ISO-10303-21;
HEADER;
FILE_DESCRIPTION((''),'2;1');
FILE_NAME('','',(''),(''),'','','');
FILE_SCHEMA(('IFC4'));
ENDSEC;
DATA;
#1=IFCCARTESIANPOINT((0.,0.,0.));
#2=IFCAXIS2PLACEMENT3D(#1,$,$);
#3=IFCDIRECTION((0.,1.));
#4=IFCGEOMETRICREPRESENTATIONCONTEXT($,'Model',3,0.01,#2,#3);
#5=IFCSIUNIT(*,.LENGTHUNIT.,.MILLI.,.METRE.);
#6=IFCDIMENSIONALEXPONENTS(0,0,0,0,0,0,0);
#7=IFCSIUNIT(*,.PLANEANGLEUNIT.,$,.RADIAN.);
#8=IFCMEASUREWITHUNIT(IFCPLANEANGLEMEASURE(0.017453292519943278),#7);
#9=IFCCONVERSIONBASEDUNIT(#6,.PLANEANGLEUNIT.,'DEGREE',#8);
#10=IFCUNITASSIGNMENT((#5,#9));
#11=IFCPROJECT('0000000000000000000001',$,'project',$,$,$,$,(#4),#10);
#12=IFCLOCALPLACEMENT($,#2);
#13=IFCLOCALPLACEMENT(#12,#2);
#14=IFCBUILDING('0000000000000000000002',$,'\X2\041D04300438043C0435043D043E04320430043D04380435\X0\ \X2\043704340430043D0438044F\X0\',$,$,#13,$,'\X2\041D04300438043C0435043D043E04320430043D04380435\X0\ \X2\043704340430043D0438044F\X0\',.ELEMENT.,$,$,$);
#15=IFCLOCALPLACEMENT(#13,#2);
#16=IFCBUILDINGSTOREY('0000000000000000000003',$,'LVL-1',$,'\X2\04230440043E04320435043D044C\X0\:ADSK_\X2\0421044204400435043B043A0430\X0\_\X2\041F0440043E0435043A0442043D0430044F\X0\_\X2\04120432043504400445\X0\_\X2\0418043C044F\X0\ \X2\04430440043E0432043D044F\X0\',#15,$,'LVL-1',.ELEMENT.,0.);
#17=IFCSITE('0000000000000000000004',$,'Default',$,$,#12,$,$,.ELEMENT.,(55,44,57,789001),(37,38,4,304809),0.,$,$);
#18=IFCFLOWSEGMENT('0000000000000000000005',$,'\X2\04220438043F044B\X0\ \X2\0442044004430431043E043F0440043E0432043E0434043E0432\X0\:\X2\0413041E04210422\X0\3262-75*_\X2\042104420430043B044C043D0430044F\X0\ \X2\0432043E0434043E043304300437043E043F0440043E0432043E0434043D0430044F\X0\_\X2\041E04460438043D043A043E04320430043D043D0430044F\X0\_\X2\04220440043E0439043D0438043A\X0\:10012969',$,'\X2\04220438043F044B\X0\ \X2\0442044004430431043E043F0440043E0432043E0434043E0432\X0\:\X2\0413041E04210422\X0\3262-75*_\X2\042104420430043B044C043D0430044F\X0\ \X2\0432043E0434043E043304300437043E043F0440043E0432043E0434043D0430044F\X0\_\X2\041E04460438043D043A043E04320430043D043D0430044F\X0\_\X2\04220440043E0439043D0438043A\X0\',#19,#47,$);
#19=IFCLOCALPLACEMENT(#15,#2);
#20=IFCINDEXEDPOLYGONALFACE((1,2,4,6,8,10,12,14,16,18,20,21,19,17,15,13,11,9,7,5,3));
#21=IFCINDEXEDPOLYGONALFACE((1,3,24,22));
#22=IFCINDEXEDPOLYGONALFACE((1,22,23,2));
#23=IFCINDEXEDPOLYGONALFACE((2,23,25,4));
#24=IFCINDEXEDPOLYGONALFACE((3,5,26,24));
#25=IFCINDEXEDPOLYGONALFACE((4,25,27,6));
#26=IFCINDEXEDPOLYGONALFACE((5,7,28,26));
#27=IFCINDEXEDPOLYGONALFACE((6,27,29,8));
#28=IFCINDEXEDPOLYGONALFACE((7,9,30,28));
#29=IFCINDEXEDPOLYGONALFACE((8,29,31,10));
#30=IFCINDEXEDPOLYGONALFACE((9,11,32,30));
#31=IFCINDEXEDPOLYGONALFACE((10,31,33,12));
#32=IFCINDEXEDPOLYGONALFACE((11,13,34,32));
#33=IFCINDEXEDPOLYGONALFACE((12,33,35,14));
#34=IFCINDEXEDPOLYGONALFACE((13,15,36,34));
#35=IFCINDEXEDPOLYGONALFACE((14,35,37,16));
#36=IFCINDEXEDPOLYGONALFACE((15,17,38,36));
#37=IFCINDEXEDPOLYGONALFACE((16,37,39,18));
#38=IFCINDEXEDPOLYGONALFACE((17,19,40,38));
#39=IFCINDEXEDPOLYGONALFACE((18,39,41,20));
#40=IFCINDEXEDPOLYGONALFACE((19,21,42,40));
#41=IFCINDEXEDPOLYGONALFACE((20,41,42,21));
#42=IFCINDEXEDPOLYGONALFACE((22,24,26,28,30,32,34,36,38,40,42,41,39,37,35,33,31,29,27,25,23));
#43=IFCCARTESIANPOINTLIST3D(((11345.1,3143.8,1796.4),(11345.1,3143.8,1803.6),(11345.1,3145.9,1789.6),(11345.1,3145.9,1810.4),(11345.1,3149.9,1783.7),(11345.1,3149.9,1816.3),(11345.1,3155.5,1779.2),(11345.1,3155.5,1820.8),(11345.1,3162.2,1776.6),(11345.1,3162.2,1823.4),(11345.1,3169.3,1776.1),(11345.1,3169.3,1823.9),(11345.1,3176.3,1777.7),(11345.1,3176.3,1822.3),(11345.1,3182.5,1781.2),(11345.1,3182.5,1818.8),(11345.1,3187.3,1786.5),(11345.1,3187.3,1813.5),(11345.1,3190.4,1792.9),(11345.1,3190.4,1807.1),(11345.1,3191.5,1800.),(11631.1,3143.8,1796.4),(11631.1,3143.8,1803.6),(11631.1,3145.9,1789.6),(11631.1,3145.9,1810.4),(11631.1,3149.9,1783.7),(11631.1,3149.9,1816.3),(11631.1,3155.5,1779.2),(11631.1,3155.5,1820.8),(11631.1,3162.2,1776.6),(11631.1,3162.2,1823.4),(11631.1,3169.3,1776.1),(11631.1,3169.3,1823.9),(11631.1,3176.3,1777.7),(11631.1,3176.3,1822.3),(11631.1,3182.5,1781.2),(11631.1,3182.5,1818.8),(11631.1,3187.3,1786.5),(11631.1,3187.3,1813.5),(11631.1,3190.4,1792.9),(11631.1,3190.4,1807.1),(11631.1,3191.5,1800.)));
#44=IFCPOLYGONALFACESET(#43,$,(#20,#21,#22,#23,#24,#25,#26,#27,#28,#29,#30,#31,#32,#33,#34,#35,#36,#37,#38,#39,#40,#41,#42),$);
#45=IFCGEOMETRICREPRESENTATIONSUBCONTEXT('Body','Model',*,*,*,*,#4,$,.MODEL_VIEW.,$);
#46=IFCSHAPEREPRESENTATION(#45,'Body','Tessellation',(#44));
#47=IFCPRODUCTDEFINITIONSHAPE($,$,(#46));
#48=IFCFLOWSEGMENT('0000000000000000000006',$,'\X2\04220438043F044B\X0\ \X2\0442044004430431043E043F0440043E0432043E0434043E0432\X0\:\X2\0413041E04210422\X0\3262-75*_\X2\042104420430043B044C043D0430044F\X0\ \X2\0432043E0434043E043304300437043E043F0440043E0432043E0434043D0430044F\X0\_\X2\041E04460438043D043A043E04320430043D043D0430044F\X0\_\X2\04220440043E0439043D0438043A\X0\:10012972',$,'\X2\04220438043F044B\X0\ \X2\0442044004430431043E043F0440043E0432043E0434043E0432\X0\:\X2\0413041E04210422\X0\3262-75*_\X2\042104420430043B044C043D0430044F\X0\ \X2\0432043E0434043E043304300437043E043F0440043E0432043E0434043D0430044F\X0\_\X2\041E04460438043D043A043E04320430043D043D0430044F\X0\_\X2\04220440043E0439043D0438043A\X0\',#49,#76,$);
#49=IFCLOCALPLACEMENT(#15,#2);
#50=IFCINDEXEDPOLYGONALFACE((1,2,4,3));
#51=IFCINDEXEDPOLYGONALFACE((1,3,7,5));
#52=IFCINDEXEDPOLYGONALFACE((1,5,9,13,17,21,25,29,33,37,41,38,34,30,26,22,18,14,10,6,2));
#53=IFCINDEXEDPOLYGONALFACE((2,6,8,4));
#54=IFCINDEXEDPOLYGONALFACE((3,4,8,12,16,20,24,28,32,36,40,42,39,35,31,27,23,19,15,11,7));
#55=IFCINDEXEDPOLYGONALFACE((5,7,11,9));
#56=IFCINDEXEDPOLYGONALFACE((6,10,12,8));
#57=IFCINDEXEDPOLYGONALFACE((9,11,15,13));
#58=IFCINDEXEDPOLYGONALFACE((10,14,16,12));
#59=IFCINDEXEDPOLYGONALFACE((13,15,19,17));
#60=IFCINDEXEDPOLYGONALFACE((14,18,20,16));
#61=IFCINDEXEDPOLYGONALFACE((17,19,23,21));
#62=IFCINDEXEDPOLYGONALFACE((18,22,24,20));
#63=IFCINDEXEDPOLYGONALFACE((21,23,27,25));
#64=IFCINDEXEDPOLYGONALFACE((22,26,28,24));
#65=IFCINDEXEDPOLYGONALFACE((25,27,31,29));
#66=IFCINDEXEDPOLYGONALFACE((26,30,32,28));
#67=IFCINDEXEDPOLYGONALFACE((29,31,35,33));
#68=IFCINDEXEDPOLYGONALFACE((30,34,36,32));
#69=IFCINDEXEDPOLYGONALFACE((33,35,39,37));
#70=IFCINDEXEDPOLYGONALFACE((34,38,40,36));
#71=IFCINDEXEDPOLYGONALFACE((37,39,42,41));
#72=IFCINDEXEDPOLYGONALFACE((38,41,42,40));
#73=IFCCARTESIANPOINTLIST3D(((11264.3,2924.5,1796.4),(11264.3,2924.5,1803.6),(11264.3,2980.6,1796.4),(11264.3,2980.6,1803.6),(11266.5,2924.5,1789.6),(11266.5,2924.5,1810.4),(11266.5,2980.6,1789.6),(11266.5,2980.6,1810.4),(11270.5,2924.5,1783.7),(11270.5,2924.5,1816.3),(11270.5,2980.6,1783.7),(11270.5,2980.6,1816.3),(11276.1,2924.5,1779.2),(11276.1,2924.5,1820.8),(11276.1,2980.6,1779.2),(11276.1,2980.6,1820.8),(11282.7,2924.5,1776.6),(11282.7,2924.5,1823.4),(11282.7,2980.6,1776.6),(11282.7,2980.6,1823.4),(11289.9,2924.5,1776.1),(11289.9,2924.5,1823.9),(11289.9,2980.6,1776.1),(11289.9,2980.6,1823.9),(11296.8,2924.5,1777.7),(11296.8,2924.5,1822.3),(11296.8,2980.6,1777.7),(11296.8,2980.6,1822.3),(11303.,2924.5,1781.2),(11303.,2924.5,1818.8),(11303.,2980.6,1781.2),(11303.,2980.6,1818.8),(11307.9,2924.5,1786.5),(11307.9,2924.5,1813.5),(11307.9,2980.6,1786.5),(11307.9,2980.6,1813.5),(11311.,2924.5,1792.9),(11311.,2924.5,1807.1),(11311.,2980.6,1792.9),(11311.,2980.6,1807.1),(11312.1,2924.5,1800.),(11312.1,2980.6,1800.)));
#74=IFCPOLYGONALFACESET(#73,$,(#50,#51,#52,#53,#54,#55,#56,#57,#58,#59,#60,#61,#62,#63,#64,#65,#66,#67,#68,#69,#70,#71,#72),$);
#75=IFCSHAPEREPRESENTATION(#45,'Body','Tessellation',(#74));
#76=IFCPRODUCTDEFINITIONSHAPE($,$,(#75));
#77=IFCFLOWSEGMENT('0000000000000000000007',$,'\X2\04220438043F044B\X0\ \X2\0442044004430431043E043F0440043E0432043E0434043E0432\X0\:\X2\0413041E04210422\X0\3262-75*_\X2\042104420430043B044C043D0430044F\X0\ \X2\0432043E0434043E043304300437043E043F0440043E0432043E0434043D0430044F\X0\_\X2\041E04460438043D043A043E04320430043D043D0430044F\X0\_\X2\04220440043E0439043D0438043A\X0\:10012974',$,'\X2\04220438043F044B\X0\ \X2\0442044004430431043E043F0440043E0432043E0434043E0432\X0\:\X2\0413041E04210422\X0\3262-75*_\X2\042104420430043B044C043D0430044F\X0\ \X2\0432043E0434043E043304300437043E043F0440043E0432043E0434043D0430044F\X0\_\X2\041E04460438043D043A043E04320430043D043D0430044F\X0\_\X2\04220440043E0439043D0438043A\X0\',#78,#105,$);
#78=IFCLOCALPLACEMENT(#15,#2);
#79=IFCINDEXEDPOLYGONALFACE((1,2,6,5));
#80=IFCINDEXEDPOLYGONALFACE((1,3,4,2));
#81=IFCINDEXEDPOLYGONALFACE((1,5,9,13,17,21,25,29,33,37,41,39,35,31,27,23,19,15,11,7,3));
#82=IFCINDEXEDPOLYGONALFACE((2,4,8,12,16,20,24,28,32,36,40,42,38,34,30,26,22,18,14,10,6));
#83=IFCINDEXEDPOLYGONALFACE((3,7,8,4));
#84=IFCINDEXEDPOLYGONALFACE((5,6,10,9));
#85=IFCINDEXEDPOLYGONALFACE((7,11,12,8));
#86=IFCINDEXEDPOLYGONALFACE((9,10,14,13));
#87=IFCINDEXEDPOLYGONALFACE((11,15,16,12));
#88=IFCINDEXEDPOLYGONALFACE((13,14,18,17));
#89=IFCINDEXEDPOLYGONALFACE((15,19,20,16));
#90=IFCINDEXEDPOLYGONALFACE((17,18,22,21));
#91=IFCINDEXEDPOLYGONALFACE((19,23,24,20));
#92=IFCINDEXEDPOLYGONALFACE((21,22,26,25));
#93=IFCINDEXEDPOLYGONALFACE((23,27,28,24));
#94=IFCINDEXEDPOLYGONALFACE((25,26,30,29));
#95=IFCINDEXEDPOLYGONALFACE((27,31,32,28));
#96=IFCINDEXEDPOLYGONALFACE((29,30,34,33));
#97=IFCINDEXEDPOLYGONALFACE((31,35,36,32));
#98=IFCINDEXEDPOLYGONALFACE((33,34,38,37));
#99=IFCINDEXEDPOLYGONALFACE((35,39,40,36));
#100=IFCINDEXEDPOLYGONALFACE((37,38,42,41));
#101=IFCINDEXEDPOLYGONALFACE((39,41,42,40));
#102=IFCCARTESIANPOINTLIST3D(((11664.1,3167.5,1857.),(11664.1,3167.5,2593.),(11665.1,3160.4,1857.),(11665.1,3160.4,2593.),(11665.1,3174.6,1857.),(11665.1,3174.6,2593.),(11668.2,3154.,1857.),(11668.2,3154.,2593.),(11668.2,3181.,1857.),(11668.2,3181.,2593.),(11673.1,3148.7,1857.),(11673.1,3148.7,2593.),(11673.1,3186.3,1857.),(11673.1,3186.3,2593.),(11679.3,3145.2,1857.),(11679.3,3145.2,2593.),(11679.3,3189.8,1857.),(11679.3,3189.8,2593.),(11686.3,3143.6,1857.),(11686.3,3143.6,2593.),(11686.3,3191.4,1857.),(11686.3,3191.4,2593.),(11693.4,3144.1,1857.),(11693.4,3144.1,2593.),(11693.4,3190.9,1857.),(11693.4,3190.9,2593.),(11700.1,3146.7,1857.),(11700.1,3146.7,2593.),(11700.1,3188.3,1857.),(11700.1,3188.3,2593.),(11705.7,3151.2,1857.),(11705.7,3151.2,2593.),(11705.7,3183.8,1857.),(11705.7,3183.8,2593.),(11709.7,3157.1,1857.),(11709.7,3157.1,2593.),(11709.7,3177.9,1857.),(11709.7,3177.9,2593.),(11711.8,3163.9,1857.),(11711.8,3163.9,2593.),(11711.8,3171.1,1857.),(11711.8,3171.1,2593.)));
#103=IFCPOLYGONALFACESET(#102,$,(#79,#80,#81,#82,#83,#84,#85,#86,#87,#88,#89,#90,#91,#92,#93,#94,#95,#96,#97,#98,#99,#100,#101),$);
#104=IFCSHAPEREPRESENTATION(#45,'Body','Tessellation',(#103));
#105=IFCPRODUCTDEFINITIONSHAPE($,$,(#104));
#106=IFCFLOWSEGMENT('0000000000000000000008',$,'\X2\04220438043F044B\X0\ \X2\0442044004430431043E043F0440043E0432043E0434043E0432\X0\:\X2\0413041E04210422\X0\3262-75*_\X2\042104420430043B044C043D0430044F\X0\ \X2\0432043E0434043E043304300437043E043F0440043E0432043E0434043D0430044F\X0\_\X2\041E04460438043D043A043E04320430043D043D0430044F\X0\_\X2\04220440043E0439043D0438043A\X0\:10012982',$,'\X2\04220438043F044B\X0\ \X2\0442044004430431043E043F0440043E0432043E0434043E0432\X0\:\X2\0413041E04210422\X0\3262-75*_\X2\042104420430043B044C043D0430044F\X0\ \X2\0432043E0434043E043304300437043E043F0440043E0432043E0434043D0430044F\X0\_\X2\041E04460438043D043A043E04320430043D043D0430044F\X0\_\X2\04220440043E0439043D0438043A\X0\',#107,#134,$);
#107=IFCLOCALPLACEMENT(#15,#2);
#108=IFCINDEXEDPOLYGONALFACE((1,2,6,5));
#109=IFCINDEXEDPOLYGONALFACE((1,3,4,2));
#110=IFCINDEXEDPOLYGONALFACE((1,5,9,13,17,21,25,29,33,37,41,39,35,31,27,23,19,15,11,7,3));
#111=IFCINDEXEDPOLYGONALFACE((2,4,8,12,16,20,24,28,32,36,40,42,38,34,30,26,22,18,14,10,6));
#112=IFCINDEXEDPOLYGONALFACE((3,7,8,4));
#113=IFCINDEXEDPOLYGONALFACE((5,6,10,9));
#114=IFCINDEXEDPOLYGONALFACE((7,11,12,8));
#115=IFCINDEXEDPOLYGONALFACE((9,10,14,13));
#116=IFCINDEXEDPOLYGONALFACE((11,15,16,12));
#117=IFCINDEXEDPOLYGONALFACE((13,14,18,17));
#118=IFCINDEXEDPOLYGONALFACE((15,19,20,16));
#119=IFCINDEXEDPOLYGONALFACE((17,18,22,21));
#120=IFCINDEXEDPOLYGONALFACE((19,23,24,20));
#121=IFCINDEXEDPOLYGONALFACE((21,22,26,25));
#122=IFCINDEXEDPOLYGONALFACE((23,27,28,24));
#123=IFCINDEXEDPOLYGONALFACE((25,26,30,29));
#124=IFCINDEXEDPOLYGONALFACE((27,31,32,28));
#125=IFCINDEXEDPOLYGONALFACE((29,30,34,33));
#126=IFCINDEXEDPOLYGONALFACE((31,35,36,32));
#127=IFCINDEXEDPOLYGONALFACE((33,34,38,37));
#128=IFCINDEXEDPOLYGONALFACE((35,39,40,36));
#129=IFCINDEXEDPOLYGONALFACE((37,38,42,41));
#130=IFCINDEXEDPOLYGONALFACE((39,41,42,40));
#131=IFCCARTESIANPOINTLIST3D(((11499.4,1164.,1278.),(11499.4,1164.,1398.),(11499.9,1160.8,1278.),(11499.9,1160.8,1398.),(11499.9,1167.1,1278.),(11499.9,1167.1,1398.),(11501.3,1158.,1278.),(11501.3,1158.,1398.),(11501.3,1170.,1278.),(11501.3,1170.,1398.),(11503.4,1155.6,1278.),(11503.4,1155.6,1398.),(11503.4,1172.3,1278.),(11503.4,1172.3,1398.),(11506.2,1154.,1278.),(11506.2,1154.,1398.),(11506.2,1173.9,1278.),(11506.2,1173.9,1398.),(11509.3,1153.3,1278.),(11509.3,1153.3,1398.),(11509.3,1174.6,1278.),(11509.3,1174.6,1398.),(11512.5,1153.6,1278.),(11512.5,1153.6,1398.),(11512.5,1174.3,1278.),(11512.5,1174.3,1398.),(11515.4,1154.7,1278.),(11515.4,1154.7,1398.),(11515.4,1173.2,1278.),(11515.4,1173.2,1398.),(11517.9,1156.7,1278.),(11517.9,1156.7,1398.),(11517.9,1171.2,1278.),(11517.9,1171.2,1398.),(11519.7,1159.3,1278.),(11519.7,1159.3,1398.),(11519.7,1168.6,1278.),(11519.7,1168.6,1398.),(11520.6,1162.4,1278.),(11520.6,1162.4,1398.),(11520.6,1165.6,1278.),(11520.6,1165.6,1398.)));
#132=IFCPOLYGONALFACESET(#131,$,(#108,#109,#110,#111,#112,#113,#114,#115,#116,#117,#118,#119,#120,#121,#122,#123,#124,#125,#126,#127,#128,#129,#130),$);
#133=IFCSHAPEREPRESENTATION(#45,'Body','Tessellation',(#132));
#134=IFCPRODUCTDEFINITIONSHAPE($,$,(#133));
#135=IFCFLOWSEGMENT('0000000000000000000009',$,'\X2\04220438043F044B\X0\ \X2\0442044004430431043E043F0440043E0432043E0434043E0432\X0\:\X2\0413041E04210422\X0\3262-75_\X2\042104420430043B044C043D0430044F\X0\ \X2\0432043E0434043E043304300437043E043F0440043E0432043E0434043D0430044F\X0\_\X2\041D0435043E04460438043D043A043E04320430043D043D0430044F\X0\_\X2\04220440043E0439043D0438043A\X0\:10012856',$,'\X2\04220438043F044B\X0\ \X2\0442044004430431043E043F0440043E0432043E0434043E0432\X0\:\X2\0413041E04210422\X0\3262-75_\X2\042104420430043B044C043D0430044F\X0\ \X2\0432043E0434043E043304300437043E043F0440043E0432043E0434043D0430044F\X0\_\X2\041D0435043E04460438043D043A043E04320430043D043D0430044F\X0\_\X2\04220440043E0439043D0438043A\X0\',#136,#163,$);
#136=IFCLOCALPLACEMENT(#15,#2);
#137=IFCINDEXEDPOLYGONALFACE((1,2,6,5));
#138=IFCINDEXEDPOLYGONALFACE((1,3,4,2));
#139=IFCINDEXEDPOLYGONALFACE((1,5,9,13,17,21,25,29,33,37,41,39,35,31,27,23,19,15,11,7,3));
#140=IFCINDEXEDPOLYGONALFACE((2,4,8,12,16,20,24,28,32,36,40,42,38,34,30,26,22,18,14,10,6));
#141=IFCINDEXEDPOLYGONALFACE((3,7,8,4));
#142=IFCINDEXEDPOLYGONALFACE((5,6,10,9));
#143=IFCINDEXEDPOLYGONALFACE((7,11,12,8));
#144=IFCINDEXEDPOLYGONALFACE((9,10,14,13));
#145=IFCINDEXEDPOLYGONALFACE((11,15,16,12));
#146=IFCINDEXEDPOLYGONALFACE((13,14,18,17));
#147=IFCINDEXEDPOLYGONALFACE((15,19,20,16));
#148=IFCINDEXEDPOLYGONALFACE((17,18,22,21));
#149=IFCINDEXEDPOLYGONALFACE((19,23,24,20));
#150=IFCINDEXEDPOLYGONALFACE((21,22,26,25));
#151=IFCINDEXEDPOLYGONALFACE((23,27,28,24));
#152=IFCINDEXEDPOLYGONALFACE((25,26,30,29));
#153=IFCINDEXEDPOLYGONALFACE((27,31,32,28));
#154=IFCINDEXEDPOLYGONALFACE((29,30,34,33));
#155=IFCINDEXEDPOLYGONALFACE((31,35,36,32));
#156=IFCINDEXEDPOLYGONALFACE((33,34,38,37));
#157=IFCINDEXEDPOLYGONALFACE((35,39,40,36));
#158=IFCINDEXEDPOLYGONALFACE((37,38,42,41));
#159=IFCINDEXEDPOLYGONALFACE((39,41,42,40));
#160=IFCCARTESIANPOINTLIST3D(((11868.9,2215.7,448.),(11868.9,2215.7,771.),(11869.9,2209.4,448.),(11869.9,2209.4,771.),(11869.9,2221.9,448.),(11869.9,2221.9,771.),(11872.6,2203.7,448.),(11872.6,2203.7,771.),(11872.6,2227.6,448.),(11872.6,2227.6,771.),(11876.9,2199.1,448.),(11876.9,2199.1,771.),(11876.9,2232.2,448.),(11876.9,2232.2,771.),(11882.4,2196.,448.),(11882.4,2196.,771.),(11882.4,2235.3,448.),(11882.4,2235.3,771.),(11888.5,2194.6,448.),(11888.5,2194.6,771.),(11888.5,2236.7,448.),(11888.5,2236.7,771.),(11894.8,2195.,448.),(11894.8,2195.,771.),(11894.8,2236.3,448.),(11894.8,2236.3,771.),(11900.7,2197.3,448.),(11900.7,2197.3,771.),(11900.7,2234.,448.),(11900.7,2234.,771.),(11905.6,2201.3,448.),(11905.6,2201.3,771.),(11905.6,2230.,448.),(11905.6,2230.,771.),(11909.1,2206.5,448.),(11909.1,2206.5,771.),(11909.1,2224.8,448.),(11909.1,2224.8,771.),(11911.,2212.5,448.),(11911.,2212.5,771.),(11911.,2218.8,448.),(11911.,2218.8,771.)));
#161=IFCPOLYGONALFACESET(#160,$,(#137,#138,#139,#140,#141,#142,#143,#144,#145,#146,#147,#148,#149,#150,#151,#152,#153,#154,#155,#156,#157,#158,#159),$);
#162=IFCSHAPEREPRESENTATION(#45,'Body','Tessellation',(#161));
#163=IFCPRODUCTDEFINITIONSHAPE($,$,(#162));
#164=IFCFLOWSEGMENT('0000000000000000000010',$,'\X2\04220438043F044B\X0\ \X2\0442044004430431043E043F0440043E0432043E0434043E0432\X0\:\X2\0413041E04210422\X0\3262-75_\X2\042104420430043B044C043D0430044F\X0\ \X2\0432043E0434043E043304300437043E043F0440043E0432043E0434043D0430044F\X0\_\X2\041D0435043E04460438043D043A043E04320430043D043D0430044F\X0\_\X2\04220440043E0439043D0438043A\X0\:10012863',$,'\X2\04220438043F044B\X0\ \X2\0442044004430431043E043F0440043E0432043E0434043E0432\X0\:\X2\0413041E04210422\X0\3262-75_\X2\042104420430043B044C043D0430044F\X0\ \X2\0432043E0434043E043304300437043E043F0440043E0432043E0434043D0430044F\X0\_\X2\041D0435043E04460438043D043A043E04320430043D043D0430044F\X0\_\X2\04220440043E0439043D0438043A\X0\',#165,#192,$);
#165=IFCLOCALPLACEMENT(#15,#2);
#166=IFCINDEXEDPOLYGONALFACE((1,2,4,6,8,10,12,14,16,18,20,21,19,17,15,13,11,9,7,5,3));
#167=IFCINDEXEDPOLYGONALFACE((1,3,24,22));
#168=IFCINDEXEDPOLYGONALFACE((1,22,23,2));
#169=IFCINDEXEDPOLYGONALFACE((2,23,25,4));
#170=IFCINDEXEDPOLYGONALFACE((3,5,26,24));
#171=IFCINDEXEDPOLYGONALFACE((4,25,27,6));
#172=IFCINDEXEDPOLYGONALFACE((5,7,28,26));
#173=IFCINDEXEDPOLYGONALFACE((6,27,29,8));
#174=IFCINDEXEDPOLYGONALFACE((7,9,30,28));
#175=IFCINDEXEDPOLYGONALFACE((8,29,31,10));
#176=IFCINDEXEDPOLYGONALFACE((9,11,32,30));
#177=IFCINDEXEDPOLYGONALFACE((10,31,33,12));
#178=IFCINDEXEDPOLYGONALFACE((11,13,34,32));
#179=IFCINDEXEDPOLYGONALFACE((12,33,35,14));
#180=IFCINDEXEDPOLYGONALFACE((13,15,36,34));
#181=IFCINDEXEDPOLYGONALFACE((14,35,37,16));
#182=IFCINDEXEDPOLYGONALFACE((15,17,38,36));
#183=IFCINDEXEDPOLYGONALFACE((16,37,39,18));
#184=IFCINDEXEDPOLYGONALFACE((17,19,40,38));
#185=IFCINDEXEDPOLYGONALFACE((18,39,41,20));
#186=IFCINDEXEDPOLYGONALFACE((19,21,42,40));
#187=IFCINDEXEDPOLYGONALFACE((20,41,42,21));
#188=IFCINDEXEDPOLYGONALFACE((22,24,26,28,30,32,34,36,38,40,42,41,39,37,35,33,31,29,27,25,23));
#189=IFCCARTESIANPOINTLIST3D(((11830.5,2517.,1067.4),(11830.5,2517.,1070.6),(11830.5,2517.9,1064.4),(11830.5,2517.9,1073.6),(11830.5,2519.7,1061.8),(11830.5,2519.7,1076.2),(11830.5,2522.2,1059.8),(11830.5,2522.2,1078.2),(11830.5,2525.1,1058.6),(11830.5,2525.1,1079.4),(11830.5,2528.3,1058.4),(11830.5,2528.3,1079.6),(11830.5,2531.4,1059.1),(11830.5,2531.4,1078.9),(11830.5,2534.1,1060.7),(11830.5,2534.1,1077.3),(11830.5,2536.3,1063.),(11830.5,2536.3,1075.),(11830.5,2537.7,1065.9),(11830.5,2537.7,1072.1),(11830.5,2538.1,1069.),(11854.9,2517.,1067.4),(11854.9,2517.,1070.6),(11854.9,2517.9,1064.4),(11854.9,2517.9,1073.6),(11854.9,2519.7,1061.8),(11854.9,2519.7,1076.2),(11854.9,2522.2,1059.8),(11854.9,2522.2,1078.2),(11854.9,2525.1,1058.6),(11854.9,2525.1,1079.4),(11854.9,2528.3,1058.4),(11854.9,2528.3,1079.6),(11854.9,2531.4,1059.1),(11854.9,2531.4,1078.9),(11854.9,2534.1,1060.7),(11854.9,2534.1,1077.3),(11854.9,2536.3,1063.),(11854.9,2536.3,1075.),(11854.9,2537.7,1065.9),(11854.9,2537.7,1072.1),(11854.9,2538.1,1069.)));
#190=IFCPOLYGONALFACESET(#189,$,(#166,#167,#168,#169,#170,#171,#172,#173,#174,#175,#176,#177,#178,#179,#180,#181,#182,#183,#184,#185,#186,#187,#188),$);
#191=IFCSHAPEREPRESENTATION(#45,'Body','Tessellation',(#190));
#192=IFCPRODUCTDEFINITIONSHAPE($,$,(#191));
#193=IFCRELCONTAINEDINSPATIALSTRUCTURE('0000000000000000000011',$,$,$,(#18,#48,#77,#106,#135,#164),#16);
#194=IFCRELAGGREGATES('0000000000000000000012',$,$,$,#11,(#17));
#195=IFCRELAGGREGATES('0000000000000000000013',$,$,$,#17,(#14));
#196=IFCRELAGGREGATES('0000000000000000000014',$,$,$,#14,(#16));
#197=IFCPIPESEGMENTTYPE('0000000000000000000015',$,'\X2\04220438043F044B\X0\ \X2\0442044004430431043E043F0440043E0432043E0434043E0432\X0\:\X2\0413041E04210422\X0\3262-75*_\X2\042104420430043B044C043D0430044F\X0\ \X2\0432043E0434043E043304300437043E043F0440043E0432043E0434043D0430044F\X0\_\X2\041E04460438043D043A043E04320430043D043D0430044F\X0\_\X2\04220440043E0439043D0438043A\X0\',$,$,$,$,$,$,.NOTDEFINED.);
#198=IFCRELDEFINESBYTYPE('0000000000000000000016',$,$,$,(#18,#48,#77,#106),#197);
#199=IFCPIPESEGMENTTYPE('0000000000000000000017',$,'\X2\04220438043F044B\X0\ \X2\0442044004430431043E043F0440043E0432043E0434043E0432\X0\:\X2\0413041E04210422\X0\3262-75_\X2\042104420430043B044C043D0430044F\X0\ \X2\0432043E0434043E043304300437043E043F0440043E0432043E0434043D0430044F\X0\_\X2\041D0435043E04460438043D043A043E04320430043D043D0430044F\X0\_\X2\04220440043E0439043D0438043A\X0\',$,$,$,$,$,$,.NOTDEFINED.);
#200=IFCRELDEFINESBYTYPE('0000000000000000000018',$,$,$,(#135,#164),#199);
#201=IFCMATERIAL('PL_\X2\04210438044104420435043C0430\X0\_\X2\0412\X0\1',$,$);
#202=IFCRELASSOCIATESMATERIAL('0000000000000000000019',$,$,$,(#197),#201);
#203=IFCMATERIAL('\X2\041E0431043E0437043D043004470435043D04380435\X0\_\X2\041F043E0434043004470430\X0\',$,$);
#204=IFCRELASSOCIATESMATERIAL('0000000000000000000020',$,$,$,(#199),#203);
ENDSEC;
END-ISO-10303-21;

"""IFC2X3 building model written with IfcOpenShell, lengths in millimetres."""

from ifc_helpers import new_model, entity, si_unit, converted_unit, direction, frame, frame_2d, origin, origin_2d_with_axis, place, context, subcontext, project, spatial, circle, extrude, material, type_object, element, save


model = new_model("IFC2X3")

# Units and contexts
model_context = context("Model", 3, precision=0.01, world=origin(), true_north=direction((0.0, 1.0)))
body_context = subcontext(model_context, "Body", "Model", "MODEL_VIEW")
ifc_project = project(units=[si_unit("LENGTHUNIT", "METRE", prefix="MILLI"), converted_unit("PLANEANGLEUNIT", "DEGREE", entity("IfcPlaneAngleMeasure", 0.017453292519943278), si_unit("PLANEANGLEUNIT", "RADIAN"), dimensions=[0, 0, 0, 0, 0, 0, 0])], contexts=[model_context])

# Site, building, storey
site_placement = place(None, origin())
site = spatial("IfcSite", under=ifc_project, at=site_placement, Name="Default", CompositionType="ELEMENT", RefLatitude=(55, 44, 57, 789001), RefLongitude=(37, 38, 4, 304809), RefElevation=0.0)
building_placement = place(site_placement, origin())
building = spatial("IfcBuilding", under=site, at=building_placement, Name="Наименование здания", LongName="Наименование здания", CompositionType="ELEMENT")
storey_placement = place(building_placement, origin())
storey = spatial("IfcBuildingStorey", under=building, at=storey_placement, Name="LVL-1", ObjectType="Уровень:ADSK_Стрелка_Проектная_Вверх_Имя уровня", LongName="LVL-1", CompositionType="ELEMENT", Elevation=0.0)

# Flow segments
ifc_material_1 = material(Name="PL_Система_В1")
pipe_segment_type_1 = type_object("IfcPipeSegmentType", Name="Типы трубопроводов:ГОСТ3262-75*_Стальная водогазопроводная_Оцинкованная_Тройник", PredefinedType="NOTDEFINED", material=ifc_material_1)
flow_segment_1_placement = place(storey_placement, origin())
element("IfcFlowSegment", 1, at=flow_segment_1_placement, inside=storey, type_object=pipe_segment_type_1, Name="Типы трубопроводов:ГОСТ3262-75*_Стальная водогазопроводная_Оцинкованная_Тройник:10012969", ObjectType="Типы трубопроводов:ГОСТ3262-75*_Стальная водогазопроводная_Оцинкованная_Тройник", context=body_context, shape_type="SweptSolid", body=[
    extrude(circle(Radius=24.0, at=frame_2d((0.0, 0.0), x_axis=(1.0, 0.0))), frame((11345.1, 3167.5, 1800.0), z_axis=(1.0, 0.0, 0.0), x_axis=(0.0, 1.0, 0.0)), (0.0, 0.0, 1.0), 286.0),
])
flow_segment_2_placement = place(storey_placement, origin())
element("IfcFlowSegment", 2, at=flow_segment_2_placement, inside=storey, type_object=pipe_segment_type_1, Name="Типы трубопроводов:ГОСТ3262-75*_Стальная водогазопроводная_Оцинкованная_Тройник:10012972", ObjectType="Типы трубопроводов:ГОСТ3262-75*_Стальная водогазопроводная_Оцинкованная_Тройник", context=body_context, shape_type="SweptSolid", body=[
    extrude(circle(Radius=24.0, at=origin_2d_with_axis()), frame((11288.1, 2924.5, 1800.0), z_axis=(0.0, 1.0, 0.0), x_axis=(1.0, 0.0, 0.0)), (0.0, 0.0, 1.0), 56.1),
])
flow_segment_3_placement = place(storey_placement, origin())
element("IfcFlowSegment", 3, at=flow_segment_3_placement, inside=storey, type_object=pipe_segment_type_1, Name="Типы трубопроводов:ГОСТ3262-75*_Стальная водогазопроводная_Оцинкованная_Тройник:10012974", ObjectType="Типы трубопроводов:ГОСТ3262-75*_Стальная водогазопроводная_Оцинкованная_Тройник", context=body_context, shape_type="SweptSolid", body=[
    extrude(circle(Radius=24.0, at=origin_2d_with_axis()), frame((11688.1, 3167.5, 1857.0), z_axis=(0.0, 0.0, 1.0), x_axis=(-1.0, 0.0, 0.0)), (0.0, 0.0, 1.0), 736.0),
])
flow_segment_4_placement = place(storey_placement, origin())
element("IfcFlowSegment", 4, at=flow_segment_4_placement, inside=storey, type_object=pipe_segment_type_1, Name="Типы трубопроводов:ГОСТ3262-75*_Стальная водогазопроводная_Оцинкованная_Тройник:10012982", ObjectType="Типы трубопроводов:ГОСТ3262-75*_Стальная водогазопроводная_Оцинкованная_Тройник", context=body_context, shape_type="SweptSolid", body=[
    extrude(circle(Radius=10.7, at=origin_2d_with_axis()), frame((11510.1, 1164.0, 1278.0), z_axis=(0.0, 0.0, 1.0), x_axis=(-1.0, 0.0, 0.0)), (0.0, 0.0, 1.0), 120.0),
])
ifc_material_2 = material(Name="Обозначение_Подача")
pipe_segment_type_2 = type_object("IfcPipeSegmentType", Name="Типы трубопроводов:ГОСТ3262-75_Стальная водогазопроводная_Неоцинкованная_Тройник", PredefinedType="NOTDEFINED", material=ifc_material_2)
flow_segment_5_placement = place(storey_placement, origin())
element("IfcFlowSegment", 5, at=flow_segment_5_placement, inside=storey, type_object=pipe_segment_type_2, Name="Типы трубопроводов:ГОСТ3262-75_Стальная водогазопроводная_Неоцинкованная_Тройник:10012856", ObjectType="Типы трубопроводов:ГОСТ3262-75_Стальная водогазопроводная_Неоцинкованная_Тройник", context=body_context, shape_type="SweptSolid", body=[
    extrude(circle(Radius=21.1, at=origin_2d_with_axis()), frame((11890.1, 2215.7, 448.0), z_axis=(0.0, 0.0, 1.0), x_axis=(-1.0, 0.0, 0.0)), (0.0, 0.0, 1.0), 323.0),
])
flow_segment_6_placement = place(storey_placement, origin())
element("IfcFlowSegment", 6, at=flow_segment_6_placement, inside=storey, type_object=pipe_segment_type_2, Name="Типы трубопроводов:ГОСТ3262-75_Стальная водогазопроводная_Неоцинкованная_Тройник:10012863", ObjectType="Типы трубопроводов:ГОСТ3262-75_Стальная водогазопроводная_Неоцинкованная_Тройник", context=body_context, shape_type="SweptSolid", body=[
    extrude(circle(Radius=10.7, at=origin_2d_with_axis()), frame((11830.5, 2527.5, 1069.0), z_axis=(1.0, 0.0, 0.0), x_axis=(0.0, 1.0, 0.0)), (0.0, 0.0, 1.0), 24.4),
])

save(model, "model.ifc")
